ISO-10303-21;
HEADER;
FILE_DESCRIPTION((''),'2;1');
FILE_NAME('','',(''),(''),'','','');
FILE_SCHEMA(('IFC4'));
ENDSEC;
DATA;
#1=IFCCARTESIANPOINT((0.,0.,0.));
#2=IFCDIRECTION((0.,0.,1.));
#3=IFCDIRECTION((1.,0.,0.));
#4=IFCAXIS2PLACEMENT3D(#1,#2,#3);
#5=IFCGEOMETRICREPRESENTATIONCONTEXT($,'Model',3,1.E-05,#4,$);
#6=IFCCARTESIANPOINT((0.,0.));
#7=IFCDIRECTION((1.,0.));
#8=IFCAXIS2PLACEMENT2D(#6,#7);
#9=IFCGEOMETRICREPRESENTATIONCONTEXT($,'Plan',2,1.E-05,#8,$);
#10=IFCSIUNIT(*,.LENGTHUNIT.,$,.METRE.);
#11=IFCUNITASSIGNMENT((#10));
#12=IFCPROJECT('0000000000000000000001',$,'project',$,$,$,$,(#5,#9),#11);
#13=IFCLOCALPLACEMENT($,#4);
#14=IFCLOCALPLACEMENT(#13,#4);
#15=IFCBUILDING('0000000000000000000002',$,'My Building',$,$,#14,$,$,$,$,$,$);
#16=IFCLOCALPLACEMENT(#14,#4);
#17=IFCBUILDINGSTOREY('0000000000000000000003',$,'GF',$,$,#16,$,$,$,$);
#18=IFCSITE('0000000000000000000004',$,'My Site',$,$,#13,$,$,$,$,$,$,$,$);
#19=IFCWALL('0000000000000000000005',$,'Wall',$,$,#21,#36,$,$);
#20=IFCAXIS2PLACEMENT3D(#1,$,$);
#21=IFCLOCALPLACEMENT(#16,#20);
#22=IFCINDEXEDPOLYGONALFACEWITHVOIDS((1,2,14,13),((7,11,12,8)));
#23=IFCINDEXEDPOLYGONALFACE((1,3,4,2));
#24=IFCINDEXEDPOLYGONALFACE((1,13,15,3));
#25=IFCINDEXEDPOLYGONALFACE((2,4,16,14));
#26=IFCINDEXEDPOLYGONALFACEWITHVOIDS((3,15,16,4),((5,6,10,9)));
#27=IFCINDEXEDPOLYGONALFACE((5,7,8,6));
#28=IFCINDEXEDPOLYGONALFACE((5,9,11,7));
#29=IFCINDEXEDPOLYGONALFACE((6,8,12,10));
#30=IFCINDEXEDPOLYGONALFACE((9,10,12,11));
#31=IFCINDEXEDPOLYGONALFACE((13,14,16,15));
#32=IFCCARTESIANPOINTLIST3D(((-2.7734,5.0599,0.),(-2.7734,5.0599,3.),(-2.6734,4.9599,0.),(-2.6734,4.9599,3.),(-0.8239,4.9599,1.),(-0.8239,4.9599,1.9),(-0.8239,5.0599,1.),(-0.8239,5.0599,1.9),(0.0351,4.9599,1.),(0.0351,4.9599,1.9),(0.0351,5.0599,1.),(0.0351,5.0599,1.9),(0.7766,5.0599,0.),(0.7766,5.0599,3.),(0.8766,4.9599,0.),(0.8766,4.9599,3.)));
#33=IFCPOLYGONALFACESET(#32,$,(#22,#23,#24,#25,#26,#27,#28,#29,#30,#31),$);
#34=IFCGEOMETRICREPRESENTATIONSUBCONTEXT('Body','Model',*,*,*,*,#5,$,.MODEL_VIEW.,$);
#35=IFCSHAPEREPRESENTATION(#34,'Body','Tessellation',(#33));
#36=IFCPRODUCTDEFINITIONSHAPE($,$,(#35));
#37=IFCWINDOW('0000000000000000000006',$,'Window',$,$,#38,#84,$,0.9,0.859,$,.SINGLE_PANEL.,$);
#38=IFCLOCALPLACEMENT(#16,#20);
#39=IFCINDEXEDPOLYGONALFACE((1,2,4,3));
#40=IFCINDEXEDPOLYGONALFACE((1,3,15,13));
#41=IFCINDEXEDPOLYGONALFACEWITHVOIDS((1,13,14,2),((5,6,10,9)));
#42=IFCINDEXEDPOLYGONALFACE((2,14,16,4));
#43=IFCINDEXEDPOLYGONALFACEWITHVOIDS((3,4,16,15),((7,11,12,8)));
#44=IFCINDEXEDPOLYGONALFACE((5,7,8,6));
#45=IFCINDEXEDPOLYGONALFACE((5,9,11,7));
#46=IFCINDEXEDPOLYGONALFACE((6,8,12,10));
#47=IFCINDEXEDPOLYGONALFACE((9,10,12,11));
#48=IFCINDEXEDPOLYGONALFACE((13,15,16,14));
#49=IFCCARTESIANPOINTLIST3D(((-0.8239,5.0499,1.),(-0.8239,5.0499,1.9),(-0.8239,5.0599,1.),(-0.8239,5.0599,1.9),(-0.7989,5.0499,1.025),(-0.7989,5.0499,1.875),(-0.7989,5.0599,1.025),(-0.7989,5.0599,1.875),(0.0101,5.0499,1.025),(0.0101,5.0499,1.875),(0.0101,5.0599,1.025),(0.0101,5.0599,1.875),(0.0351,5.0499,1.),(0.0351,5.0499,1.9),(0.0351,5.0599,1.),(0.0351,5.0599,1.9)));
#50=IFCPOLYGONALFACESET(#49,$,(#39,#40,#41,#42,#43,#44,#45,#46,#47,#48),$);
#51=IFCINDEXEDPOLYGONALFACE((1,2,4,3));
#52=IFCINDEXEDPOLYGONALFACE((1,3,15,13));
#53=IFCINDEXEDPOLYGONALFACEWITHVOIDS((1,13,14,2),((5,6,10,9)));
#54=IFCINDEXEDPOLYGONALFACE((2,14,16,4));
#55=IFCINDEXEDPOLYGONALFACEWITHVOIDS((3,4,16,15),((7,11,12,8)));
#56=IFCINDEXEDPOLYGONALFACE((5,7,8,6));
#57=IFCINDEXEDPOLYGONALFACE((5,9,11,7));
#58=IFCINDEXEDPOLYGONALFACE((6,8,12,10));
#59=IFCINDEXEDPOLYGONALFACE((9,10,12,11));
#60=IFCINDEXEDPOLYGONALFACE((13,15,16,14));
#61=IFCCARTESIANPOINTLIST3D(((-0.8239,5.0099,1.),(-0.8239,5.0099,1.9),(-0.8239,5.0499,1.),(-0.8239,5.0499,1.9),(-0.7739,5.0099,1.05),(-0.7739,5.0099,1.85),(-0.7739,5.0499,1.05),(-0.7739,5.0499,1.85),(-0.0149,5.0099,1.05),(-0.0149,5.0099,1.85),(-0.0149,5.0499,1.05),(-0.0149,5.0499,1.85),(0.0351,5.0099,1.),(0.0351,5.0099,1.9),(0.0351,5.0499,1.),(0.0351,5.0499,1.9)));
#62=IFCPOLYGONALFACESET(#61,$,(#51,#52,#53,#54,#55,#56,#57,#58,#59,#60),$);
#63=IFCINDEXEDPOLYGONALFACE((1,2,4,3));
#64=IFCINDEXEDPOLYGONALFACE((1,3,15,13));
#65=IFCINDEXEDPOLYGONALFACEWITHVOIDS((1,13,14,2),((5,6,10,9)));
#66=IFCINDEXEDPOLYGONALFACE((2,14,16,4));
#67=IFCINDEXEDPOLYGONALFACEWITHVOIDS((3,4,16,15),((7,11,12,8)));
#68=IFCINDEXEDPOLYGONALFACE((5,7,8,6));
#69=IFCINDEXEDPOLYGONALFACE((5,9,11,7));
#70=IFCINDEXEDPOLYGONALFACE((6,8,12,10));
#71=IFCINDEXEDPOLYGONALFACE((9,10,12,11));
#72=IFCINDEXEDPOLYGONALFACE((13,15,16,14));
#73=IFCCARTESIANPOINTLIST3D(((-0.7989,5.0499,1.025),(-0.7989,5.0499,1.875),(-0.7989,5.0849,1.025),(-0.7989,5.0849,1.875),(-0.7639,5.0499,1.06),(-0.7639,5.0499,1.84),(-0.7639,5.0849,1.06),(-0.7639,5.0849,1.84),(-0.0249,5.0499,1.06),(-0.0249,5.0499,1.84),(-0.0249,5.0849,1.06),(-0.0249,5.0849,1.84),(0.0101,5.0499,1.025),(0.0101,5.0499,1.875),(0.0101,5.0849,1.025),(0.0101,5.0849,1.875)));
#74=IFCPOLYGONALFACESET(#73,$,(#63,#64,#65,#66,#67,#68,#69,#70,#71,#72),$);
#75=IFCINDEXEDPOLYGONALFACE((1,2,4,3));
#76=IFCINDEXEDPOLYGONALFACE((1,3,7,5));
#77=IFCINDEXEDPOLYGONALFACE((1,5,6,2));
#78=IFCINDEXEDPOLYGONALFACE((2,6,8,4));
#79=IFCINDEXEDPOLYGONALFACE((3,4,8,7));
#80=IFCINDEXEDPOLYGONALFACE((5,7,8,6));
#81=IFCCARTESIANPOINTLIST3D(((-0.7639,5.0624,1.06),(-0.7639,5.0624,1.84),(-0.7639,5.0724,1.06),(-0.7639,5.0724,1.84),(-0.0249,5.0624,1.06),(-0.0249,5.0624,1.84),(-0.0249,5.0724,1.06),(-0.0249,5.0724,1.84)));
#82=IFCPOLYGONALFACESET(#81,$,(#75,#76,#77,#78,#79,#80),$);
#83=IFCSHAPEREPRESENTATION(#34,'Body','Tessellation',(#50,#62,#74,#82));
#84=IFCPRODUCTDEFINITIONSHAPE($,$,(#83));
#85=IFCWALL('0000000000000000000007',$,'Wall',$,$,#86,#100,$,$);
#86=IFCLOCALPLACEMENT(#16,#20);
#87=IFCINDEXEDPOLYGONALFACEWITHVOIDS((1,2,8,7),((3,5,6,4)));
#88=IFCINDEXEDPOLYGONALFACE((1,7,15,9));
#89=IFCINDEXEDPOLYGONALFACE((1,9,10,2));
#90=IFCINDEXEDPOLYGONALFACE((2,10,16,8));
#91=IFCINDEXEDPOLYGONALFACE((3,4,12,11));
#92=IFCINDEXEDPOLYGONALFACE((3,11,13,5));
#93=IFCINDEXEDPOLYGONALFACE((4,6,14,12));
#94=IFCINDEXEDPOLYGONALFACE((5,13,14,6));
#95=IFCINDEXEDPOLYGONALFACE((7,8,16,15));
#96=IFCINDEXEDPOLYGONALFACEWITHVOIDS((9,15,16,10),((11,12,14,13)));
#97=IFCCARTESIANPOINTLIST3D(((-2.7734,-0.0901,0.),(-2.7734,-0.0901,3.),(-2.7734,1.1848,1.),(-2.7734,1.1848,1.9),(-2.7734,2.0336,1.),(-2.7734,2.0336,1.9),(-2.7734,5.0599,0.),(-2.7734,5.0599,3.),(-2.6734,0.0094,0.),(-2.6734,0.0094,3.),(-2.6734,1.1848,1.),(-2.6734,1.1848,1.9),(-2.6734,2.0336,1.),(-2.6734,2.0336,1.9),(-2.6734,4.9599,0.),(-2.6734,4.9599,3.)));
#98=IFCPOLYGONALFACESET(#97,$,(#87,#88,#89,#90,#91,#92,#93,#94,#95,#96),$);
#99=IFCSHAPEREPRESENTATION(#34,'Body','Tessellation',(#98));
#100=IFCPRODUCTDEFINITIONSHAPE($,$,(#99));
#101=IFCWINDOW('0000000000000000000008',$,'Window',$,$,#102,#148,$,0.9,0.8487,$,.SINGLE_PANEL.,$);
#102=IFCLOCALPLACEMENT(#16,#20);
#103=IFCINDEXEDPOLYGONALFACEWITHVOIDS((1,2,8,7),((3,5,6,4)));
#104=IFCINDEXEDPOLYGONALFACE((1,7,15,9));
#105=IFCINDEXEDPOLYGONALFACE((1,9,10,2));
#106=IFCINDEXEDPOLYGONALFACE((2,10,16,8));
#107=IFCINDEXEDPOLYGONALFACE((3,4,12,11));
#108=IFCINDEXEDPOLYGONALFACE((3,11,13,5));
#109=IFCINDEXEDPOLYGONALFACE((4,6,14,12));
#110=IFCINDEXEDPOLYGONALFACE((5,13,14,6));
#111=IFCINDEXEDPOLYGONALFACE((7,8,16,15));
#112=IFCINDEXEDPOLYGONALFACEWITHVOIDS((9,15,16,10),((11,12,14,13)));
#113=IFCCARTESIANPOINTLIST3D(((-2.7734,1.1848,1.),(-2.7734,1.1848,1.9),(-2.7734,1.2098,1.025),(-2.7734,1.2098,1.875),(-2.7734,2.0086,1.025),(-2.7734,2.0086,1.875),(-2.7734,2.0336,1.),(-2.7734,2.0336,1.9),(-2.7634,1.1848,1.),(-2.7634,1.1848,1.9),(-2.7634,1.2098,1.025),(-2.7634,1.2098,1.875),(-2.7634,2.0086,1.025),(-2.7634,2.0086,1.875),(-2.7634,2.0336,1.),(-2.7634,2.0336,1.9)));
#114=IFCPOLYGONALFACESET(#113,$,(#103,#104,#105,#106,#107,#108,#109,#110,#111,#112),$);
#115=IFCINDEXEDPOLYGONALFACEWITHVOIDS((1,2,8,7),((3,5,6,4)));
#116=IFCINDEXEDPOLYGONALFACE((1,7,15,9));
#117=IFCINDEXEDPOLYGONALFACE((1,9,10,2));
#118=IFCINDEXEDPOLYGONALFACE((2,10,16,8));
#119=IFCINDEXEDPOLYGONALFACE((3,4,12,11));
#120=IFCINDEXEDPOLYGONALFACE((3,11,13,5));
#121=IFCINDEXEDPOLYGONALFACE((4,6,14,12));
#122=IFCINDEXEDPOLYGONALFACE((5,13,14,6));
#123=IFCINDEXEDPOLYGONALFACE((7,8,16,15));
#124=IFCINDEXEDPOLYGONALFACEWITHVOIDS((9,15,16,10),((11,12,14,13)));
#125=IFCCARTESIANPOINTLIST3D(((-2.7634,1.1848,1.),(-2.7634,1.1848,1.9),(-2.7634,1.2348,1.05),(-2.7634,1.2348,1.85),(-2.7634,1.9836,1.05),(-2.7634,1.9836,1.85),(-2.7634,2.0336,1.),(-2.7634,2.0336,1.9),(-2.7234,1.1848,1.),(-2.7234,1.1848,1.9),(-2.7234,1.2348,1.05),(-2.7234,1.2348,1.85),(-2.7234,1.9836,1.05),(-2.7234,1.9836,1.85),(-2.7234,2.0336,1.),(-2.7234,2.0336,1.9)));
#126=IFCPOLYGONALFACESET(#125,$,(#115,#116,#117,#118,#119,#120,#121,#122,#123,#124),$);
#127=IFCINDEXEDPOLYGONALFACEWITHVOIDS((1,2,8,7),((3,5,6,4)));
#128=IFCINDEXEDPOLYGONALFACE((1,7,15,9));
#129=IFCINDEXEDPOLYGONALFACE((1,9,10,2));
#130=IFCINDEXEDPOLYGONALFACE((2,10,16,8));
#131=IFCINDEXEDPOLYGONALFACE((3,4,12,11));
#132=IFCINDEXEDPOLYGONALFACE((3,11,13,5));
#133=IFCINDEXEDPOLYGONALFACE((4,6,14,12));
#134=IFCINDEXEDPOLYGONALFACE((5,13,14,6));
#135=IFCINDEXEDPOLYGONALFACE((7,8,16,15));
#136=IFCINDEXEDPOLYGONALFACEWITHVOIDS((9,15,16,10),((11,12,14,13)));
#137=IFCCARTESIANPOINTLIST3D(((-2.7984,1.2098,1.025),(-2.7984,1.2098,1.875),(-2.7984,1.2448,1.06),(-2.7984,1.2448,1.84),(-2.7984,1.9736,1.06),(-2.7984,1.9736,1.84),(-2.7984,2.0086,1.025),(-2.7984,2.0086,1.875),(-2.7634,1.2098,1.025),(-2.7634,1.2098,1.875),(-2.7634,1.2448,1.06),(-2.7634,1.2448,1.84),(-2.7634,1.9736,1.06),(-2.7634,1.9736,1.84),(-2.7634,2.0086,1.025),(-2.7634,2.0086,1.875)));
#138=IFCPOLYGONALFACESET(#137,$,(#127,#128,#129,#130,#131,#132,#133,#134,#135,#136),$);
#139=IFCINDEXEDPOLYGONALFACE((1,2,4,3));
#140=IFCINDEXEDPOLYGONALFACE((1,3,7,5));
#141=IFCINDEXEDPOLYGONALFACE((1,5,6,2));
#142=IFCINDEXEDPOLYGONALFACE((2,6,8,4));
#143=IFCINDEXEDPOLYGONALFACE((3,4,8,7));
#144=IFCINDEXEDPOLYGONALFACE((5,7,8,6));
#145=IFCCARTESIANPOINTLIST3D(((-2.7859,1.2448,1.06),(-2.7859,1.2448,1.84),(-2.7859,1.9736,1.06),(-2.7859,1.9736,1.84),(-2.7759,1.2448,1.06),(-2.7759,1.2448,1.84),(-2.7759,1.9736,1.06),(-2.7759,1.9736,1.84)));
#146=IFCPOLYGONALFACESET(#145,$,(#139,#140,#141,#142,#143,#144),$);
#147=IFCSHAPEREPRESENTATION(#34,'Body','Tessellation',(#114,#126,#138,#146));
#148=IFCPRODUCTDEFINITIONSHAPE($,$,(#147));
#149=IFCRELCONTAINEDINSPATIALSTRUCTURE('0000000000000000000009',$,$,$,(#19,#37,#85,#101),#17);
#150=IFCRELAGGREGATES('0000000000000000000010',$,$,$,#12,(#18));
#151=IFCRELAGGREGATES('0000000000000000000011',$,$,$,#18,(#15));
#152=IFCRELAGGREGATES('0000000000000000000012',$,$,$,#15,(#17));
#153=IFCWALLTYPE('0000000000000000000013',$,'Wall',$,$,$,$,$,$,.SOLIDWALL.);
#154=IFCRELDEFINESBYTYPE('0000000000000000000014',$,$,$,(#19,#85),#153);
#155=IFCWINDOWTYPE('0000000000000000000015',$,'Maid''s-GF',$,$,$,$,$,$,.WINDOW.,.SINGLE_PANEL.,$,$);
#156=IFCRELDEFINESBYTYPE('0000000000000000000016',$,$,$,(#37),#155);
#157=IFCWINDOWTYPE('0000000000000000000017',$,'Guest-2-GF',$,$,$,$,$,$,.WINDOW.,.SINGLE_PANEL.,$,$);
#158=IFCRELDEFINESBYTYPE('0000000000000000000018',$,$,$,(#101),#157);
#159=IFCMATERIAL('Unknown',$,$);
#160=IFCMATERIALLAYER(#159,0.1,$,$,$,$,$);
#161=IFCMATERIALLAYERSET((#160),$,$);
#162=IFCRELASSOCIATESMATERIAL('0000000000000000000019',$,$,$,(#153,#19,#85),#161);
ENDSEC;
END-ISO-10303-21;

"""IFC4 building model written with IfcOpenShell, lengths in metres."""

from ifc_helpers import new_model, entity, si_unit, frame, origin_with_axes, origin_2d_with_axis, place, context, subcontext, project, spatial, line, indexed_curve, outline, extrude, shape, source, transform, mapped, material, layer, layer_set, layer_usage, type_object, type_shapes, element, fill, save


model = new_model("IFC4")

# Units and contexts
model_context = context("Model", 3, precision=1e-05, world=origin_with_axes())
plan_context = context("Plan", 2, precision=1e-05, world=origin_2d_with_axis())
body_context_1 = subcontext(model_context, "Body", "Model", "MODEL_VIEW")
body_context_2 = subcontext(plan_context, "Body", "Plan", "PLAN_VIEW")
ifc_project = project(units=[si_unit("LENGTHUNIT", "METRE")], contexts=[model_context, plan_context])

# Site, building, storey
site_placement = place(None, origin_with_axes())
site = spatial("IfcSite", under=ifc_project, at=site_placement, Name="My Site")
building_placement = place(site_placement, origin_with_axes())
building = spatial("IfcBuilding", under=site, at=building_placement, Name="My Building")
storey_placement = place(building_placement, origin_with_axes())
storey = spatial("IfcBuildingStorey", under=building, at=storey_placement, Name="GF")

# Shared definitions
ifc_material_1 = material(Name="Unknown")

# Shared definitions
ifc_layer_1 = layer(ifc_material_1, 0.1)
ifc_layer_set_1 = layer_set([ifc_layer_1])
wall_type = type_object("IfcWallType", Name="Wall", PredefinedType="SOLIDWALL", material=ifc_layer_set_1)

# Walls, openings, windows
ifc_layer_usage_1 = layer_usage(ifc_layer_set_1, "AXIS2", "POSITIVE", 0.0)
wall_1_placement = place(storey_placement, frame((0.7766, 5.0599, 0.0), z_axis=(0.0, 0.0, 1.0), x_axis=(-1.0, 0.0, 0.0)))
wall_1 = element("IfcWall", 1, at=wall_1_placement, inside=storey, type_object=wall_type, material=ifc_layer_usage_1, Name="Wall", context=body_context_1, shape_type="SweptSolid", body=[
    extrude(outline(indexed_curve([(0.0, 0.0), (-0.1, 0.1), (3.45, 0.1), (3.55, 0.0)], segments=[line(1, 2, 3, 4, 1)])), origin_with_axes(), (0.0, 0.0, 1.0), 3.0),
])
shared_shape_1 = source(origin_with_axes(), body_context_1, "Body", "SweptSolid", [
    extrude(outline(indexed_curve([(0.0, 0.0), (0.859, 0.0), (0.859, 0.9), (0.0, 0.9)], segments=[line(1, 2, 3, 4, 1)])), frame((0.0, -0.6, 0.0), z_axis=(0.0, -1.0, 0.0), x_axis=(1.0, 0.0, 0.0)), (0.0, 0.0, -1.0), 1.2),
])
opening_1_placement = place(wall_1_placement, frame((1.6005, 0.1, 1.0), z_axis=(0.0, 0.0, 1.0), x_axis=(-1.0, 0.000001, 0.0)))
opening_1 = element("IfcOpeningElement", 2, at=opening_1_placement, cuts=wall_1, PredefinedType="OPENING", context=body_context_1, shape_type="MappedRepresentation", body=[
    mapped(shared_shape_1, transform((0.0, 0.0, 0.0), x_axis=(1.0, 0.0, 0.0), y_axis=(0.0, 1.0, 0.0), z_axis=(0.0, 0.0, 1.0), scale=1.0)),
])
window_type_1 = type_object("IfcWindowType", Name="Maid's-GF", PartitioningType="SINGLE_PANEL", PredefinedType="WINDOW")
shared_shape_2 = source(origin_with_axes(), body_context_1, "Body", "SweptSolid", [
    extrude(outline(indexed_curve([(0.0, 0.0), (0.859, 0.0), (0.859, 0.9), (0.0, 0.9)], segments=[line(1, 2, 3, 4, 1)]), holes=[indexed_curve([(0.025, 0.025), (0.834, 0.025), (0.834, 0.875), (0.025, 0.875)], segments=[line(1, 2, 3, 4, 1)])]), frame((0.0, 0.09, 0.0), z_axis=(0.0, -1.0, 0.0), x_axis=(1.0, 0.0, 0.0)), (0.0, 0.0, -1.0), 0.01),
    extrude(outline(indexed_curve([(0.0, 0.0), (0.859, 0.0), (0.859, 0.9), (0.0, 0.9)], segments=[line(1, 2, 3, 4, 1)]), holes=[indexed_curve([(0.05, 0.05), (0.809, 0.05), (0.809, 0.85), (0.05, 0.85)], segments=[line(1, 2, 3, 4, 1)])]), frame((0.0, 0.05, 0.0), z_axis=(0.0, -1.0, 0.0), x_axis=(1.0, 0.0, 0.0)), (0.0, 0.0, -1.0), 0.04),
    extrude(outline(indexed_curve([(0.0, 0.0), (0.809, 0.0), (0.809, 0.85), (0.0, 0.85)], segments=[line(1, 2, 3, 4, 1)]), holes=[indexed_curve([(0.035, 0.035), (0.774, 0.035), (0.774, 0.815), (0.035, 0.815)], segments=[line(1, 2, 3, 4, 1)])]), frame((0.025, 0.09, 0.025), z_axis=(0.0, -1.0, 0.0), x_axis=(1.0, 0.0, 0.0)), (0.0, 0.0, -1.0), 0.035),
    extrude(outline(indexed_curve([(0.035, 0.035), (0.774, 0.035), (0.774, 0.815), (0.035, 0.815)], segments=[line(1, 2, 3, 4, 1)])), frame((0.025, 0.1025, 0.025), z_axis=(0.0, -1.0, 0.0), x_axis=(1.0, 0.0, 0.0)), (0.0, 0.0, -1.0), 0.01),
])
shared_shape_3 = source(origin_with_axes(), body_context_2, "Body", "Curve2D", [
    entity("IfcIndexedPolyCurve", entity("IfcCartesianPointList2D", [[0.05, 0.05], [0.809, 0.05]])),
    entity("IfcIndexedPolyCurve", entity("IfcCartesianPointList2D", [[0.0, 0.1], [0.025, 0.1], [0.025, 0.09], [0.05, 0.09], [0.05, 0.05], [0.0, 0.05]]), [entity("IfcLineIndex", [1, 2, 3, 4, 5, 6, 1])]),
    entity("IfcIndexedPolyCurve", entity("IfcCartesianPointList2D", [[0.859, 0.1], [0.834, 0.1], [0.834, 0.09], [0.809, 0.09], [0.809, 0.05], [0.859, 0.05]]), [entity("IfcLineIndex", [1, 2, 3, 4, 5, 6, 1])]),
    entity("IfcIndexedPolyCurve", entity("IfcCartesianPointList2D", [[0.025, 0.09], [0.06, 0.09], [0.06, 0.125], [0.025, 0.125]]), [entity("IfcLineIndex", [1, 2, 3, 4, 1])]),
    entity("IfcIndexedPolyCurve", entity("IfcCartesianPointList2D", [[0.834, 0.09], [0.799, 0.09], [0.799, 0.125], [0.834, 0.125]]), [entity("IfcLineIndex", [1, 2, 3, 4, 1])]),
    entity("IfcIndexedPolyCurve", entity("IfcCartesianPointList2D", [[0.06, 0.09], [0.799, 0.09]])),
    entity("IfcIndexedPolyCurve", entity("IfcCartesianPointList2D", [[0.06, 0.125], [0.799, 0.125]])),
    entity("IfcIndexedPolyCurve", entity("IfcCartesianPointList2D", [[0.06, 0.1075], [0.799, 0.1075]])),
])
type_shapes(window_type_1, [shared_shape_2, shared_shape_3])
window_1_placement = place(opening_1_placement, frame((0.0, 0.0, 0.0), z_axis=(0.0, 0.0, 1.0), x_axis=(1.0, 0.0, 0.0)))
window_1 = element("IfcWindow", 3, at=window_1_placement, inside=storey, type_object=window_type_1, Name="Window", OverallHeight=0.9, OverallWidth=0.859, PartitioningType="SINGLE_PANEL", shapes=[
    shape(body_context_1, "Body", "MappedRepresentation", [mapped(shared_shape_2, transform((0.0, 0.0, 0.0), x_axis=(1.0, 0.0, 0.0), y_axis=(0.0, 1.0, 0.0), z_axis=(0.0, 0.0, 1.0), scale=1.0))]),
    shape(body_context_2, "Body", "MappedRepresentation", [mapped(shared_shape_3, transform((0.0, 0.0, 0.0), x_axis=(1.0, 0.0, 0.0), y_axis=(0.0, 1.0, 0.0), z_axis=(0.0, 0.0, 1.0), scale=1.0))]),
])
fill(opening_1, window_1)
ifc_layer_usage_2 = layer_usage(ifc_layer_set_1, "AXIS2", "POSITIVE", 0.0)
wall_2_placement = place(storey_placement, frame((-2.7734, 5.0599, 0.0), z_axis=(0.0, 0.0, 1.0), x_axis=(0.0, -1.0, 0.0)))
wall_2 = element("IfcWall", 4, at=wall_2_placement, inside=storey, type_object=wall_type, material=ifc_layer_usage_2, Name="Wall", context=body_context_1, shape_type="SweptSolid", body=[
    extrude(outline(indexed_curve([(0.0, 0.0), (0.1, 0.1), (5.0504, 0.1), (5.15, 0.0)], segments=[line(1, 2, 3, 4, 1)])), origin_with_axes(), (0.0, 0.0, 1.0), 3.0),
])
shared_shape_4 = source(origin_with_axes(), body_context_1, "Body", "SweptSolid", [
    extrude(outline(indexed_curve([(0.0, 0.0), (0.8487, 0.0), (0.8487, 0.9), (0.0, 0.9)], segments=[line(1, 2, 3, 4, 1)])), frame((0.0, -0.6, 0.0), z_axis=(0.0, -1.0, 0.0), x_axis=(1.0, 0.0, 0.0)), (0.0, 0.0, -1.0), 1.2),
])
opening_2_placement = place(wall_2_placement, frame((3.875, 0.1, 1.0), z_axis=(0.0, 0.0, 1.0), x_axis=(-1.0, 0.0, 0.0)))
opening_2 = element("IfcOpeningElement", 5, at=opening_2_placement, cuts=wall_2, PredefinedType="OPENING", context=body_context_1, shape_type="MappedRepresentation", body=[
    mapped(shared_shape_4, transform((0.0, 0.0, 0.0), x_axis=(1.0, 0.0, 0.0), y_axis=(0.0, 1.0, 0.0), z_axis=(0.0, 0.0, 1.0), scale=1.0)),
])
window_type_2 = type_object("IfcWindowType", Name="Guest-2-GF", PartitioningType="SINGLE_PANEL", PredefinedType="WINDOW")
shared_shape_5 = source(origin_with_axes(), body_context_1, "Body", "SweptSolid", [
    extrude(outline(indexed_curve([(0.0, 0.0), (0.8487, 0.0), (0.8487, 0.9), (0.0, 0.9)], segments=[line(1, 2, 3, 4, 1)]), holes=[indexed_curve([(0.025, 0.025), (0.8237, 0.025), (0.8237, 0.875), (0.025, 0.875)], segments=[line(1, 2, 3, 4, 1)])]), frame((0.0, 0.09, 0.0), z_axis=(0.0, -1.0, 0.0), x_axis=(1.0, 0.0, 0.0)), (0.0, 0.0, -1.0), 0.01),
    extrude(outline(indexed_curve([(0.0, 0.0), (0.8487, 0.0), (0.8487, 0.9), (0.0, 0.9)], segments=[line(1, 2, 3, 4, 1)]), holes=[indexed_curve([(0.05, 0.05), (0.7987, 0.05), (0.7987, 0.85), (0.05, 0.85)], segments=[line(1, 2, 3, 4, 1)])]), frame((0.0, 0.05, 0.0), z_axis=(0.0, -1.0, 0.0), x_axis=(1.0, 0.0, 0.0)), (0.0, 0.0, -1.0), 0.04),
    extrude(outline(indexed_curve([(0.0, 0.0), (0.7987, 0.0), (0.7987, 0.85), (0.0, 0.85)], segments=[line(1, 2, 3, 4, 1)]), holes=[indexed_curve([(0.035, 0.035), (0.7637, 0.035), (0.7637, 0.815), (0.035, 0.815)], segments=[line(1, 2, 3, 4, 1)])]), frame((0.025, 0.09, 0.025), z_axis=(0.0, -1.0, 0.0), x_axis=(1.0, 0.0, 0.0)), (0.0, 0.0, -1.0), 0.035),
    extrude(outline(indexed_curve([(0.035, 0.035), (0.7637, 0.035), (0.7637, 0.815), (0.035, 0.815)], segments=[line(1, 2, 3, 4, 1)])), frame((0.025, 0.1025, 0.025), z_axis=(0.0, -1.0, 0.0), x_axis=(1.0, 0.0, 0.0)), (0.0, 0.0, -1.0), 0.01),
])
shared_shape_6 = source(origin_with_axes(), body_context_2, "Body", "Curve2D", [
    entity("IfcIndexedPolyCurve", entity("IfcCartesianPointList2D", [[0.05, 0.05], [0.7987, 0.05]])),
    entity("IfcIndexedPolyCurve", entity("IfcCartesianPointList2D", [[0.0, 0.1], [0.025, 0.1], [0.025, 0.09], [0.05, 0.09], [0.05, 0.05], [0.0, 0.05]]), [entity("IfcLineIndex", [1, 2, 3, 4, 5, 6, 1])]),
    entity("IfcIndexedPolyCurve", entity("IfcCartesianPointList2D", [[0.8487, 0.1], [0.8237, 0.1], [0.8237, 0.09], [0.7987, 0.09], [0.7987, 0.05], [0.8487, 0.05]]), [entity("IfcLineIndex", [1, 2, 3, 4, 5, 6, 1])]),
    entity("IfcIndexedPolyCurve", entity("IfcCartesianPointList2D", [[0.025, 0.09], [0.06, 0.09], [0.06, 0.125], [0.025, 0.125]]), [entity("IfcLineIndex", [1, 2, 3, 4, 1])]),
    entity("IfcIndexedPolyCurve", entity("IfcCartesianPointList2D", [[0.8237, 0.09], [0.7887, 0.09], [0.7887, 0.125], [0.8237, 0.125]]), [entity("IfcLineIndex", [1, 2, 3, 4, 1])]),
    entity("IfcIndexedPolyCurve", entity("IfcCartesianPointList2D", [[0.06, 0.09], [0.7887, 0.09]])),
    entity("IfcIndexedPolyCurve", entity("IfcCartesianPointList2D", [[0.06, 0.125], [0.7887, 0.125]])),
    entity("IfcIndexedPolyCurve", entity("IfcCartesianPointList2D", [[0.06, 0.1075], [0.7887, 0.1075]])),
])
type_shapes(window_type_2, [shared_shape_5, shared_shape_6])
window_2_placement = place(opening_2_placement, frame((0.0, 0.0, 0.0), z_axis=(0.0, 0.0, 1.0), x_axis=(1.0, 0.0, 0.0)))
window_2 = element("IfcWindow", 6, at=window_2_placement, inside=storey, type_object=window_type_2, Name="Window", OverallHeight=0.9, OverallWidth=0.8487, PartitioningType="SINGLE_PANEL", shapes=[
    shape(body_context_1, "Body", "MappedRepresentation", [mapped(shared_shape_5, transform((0.0, 0.0, 0.0), x_axis=(1.0, 0.0, 0.0), y_axis=(0.0, 1.0, 0.0), z_axis=(0.0, 0.0, 1.0), scale=1.0))]),
    shape(body_context_2, "Body", "MappedRepresentation", [mapped(shared_shape_6, transform((0.0, 0.0, 0.0), x_axis=(1.0, 0.0, 0.0), y_axis=(0.0, 1.0, 0.0), z_axis=(0.0, 0.0, 1.0), scale=1.0))]),
])
fill(opening_2, window_2)

save(model, "model.ifc")
